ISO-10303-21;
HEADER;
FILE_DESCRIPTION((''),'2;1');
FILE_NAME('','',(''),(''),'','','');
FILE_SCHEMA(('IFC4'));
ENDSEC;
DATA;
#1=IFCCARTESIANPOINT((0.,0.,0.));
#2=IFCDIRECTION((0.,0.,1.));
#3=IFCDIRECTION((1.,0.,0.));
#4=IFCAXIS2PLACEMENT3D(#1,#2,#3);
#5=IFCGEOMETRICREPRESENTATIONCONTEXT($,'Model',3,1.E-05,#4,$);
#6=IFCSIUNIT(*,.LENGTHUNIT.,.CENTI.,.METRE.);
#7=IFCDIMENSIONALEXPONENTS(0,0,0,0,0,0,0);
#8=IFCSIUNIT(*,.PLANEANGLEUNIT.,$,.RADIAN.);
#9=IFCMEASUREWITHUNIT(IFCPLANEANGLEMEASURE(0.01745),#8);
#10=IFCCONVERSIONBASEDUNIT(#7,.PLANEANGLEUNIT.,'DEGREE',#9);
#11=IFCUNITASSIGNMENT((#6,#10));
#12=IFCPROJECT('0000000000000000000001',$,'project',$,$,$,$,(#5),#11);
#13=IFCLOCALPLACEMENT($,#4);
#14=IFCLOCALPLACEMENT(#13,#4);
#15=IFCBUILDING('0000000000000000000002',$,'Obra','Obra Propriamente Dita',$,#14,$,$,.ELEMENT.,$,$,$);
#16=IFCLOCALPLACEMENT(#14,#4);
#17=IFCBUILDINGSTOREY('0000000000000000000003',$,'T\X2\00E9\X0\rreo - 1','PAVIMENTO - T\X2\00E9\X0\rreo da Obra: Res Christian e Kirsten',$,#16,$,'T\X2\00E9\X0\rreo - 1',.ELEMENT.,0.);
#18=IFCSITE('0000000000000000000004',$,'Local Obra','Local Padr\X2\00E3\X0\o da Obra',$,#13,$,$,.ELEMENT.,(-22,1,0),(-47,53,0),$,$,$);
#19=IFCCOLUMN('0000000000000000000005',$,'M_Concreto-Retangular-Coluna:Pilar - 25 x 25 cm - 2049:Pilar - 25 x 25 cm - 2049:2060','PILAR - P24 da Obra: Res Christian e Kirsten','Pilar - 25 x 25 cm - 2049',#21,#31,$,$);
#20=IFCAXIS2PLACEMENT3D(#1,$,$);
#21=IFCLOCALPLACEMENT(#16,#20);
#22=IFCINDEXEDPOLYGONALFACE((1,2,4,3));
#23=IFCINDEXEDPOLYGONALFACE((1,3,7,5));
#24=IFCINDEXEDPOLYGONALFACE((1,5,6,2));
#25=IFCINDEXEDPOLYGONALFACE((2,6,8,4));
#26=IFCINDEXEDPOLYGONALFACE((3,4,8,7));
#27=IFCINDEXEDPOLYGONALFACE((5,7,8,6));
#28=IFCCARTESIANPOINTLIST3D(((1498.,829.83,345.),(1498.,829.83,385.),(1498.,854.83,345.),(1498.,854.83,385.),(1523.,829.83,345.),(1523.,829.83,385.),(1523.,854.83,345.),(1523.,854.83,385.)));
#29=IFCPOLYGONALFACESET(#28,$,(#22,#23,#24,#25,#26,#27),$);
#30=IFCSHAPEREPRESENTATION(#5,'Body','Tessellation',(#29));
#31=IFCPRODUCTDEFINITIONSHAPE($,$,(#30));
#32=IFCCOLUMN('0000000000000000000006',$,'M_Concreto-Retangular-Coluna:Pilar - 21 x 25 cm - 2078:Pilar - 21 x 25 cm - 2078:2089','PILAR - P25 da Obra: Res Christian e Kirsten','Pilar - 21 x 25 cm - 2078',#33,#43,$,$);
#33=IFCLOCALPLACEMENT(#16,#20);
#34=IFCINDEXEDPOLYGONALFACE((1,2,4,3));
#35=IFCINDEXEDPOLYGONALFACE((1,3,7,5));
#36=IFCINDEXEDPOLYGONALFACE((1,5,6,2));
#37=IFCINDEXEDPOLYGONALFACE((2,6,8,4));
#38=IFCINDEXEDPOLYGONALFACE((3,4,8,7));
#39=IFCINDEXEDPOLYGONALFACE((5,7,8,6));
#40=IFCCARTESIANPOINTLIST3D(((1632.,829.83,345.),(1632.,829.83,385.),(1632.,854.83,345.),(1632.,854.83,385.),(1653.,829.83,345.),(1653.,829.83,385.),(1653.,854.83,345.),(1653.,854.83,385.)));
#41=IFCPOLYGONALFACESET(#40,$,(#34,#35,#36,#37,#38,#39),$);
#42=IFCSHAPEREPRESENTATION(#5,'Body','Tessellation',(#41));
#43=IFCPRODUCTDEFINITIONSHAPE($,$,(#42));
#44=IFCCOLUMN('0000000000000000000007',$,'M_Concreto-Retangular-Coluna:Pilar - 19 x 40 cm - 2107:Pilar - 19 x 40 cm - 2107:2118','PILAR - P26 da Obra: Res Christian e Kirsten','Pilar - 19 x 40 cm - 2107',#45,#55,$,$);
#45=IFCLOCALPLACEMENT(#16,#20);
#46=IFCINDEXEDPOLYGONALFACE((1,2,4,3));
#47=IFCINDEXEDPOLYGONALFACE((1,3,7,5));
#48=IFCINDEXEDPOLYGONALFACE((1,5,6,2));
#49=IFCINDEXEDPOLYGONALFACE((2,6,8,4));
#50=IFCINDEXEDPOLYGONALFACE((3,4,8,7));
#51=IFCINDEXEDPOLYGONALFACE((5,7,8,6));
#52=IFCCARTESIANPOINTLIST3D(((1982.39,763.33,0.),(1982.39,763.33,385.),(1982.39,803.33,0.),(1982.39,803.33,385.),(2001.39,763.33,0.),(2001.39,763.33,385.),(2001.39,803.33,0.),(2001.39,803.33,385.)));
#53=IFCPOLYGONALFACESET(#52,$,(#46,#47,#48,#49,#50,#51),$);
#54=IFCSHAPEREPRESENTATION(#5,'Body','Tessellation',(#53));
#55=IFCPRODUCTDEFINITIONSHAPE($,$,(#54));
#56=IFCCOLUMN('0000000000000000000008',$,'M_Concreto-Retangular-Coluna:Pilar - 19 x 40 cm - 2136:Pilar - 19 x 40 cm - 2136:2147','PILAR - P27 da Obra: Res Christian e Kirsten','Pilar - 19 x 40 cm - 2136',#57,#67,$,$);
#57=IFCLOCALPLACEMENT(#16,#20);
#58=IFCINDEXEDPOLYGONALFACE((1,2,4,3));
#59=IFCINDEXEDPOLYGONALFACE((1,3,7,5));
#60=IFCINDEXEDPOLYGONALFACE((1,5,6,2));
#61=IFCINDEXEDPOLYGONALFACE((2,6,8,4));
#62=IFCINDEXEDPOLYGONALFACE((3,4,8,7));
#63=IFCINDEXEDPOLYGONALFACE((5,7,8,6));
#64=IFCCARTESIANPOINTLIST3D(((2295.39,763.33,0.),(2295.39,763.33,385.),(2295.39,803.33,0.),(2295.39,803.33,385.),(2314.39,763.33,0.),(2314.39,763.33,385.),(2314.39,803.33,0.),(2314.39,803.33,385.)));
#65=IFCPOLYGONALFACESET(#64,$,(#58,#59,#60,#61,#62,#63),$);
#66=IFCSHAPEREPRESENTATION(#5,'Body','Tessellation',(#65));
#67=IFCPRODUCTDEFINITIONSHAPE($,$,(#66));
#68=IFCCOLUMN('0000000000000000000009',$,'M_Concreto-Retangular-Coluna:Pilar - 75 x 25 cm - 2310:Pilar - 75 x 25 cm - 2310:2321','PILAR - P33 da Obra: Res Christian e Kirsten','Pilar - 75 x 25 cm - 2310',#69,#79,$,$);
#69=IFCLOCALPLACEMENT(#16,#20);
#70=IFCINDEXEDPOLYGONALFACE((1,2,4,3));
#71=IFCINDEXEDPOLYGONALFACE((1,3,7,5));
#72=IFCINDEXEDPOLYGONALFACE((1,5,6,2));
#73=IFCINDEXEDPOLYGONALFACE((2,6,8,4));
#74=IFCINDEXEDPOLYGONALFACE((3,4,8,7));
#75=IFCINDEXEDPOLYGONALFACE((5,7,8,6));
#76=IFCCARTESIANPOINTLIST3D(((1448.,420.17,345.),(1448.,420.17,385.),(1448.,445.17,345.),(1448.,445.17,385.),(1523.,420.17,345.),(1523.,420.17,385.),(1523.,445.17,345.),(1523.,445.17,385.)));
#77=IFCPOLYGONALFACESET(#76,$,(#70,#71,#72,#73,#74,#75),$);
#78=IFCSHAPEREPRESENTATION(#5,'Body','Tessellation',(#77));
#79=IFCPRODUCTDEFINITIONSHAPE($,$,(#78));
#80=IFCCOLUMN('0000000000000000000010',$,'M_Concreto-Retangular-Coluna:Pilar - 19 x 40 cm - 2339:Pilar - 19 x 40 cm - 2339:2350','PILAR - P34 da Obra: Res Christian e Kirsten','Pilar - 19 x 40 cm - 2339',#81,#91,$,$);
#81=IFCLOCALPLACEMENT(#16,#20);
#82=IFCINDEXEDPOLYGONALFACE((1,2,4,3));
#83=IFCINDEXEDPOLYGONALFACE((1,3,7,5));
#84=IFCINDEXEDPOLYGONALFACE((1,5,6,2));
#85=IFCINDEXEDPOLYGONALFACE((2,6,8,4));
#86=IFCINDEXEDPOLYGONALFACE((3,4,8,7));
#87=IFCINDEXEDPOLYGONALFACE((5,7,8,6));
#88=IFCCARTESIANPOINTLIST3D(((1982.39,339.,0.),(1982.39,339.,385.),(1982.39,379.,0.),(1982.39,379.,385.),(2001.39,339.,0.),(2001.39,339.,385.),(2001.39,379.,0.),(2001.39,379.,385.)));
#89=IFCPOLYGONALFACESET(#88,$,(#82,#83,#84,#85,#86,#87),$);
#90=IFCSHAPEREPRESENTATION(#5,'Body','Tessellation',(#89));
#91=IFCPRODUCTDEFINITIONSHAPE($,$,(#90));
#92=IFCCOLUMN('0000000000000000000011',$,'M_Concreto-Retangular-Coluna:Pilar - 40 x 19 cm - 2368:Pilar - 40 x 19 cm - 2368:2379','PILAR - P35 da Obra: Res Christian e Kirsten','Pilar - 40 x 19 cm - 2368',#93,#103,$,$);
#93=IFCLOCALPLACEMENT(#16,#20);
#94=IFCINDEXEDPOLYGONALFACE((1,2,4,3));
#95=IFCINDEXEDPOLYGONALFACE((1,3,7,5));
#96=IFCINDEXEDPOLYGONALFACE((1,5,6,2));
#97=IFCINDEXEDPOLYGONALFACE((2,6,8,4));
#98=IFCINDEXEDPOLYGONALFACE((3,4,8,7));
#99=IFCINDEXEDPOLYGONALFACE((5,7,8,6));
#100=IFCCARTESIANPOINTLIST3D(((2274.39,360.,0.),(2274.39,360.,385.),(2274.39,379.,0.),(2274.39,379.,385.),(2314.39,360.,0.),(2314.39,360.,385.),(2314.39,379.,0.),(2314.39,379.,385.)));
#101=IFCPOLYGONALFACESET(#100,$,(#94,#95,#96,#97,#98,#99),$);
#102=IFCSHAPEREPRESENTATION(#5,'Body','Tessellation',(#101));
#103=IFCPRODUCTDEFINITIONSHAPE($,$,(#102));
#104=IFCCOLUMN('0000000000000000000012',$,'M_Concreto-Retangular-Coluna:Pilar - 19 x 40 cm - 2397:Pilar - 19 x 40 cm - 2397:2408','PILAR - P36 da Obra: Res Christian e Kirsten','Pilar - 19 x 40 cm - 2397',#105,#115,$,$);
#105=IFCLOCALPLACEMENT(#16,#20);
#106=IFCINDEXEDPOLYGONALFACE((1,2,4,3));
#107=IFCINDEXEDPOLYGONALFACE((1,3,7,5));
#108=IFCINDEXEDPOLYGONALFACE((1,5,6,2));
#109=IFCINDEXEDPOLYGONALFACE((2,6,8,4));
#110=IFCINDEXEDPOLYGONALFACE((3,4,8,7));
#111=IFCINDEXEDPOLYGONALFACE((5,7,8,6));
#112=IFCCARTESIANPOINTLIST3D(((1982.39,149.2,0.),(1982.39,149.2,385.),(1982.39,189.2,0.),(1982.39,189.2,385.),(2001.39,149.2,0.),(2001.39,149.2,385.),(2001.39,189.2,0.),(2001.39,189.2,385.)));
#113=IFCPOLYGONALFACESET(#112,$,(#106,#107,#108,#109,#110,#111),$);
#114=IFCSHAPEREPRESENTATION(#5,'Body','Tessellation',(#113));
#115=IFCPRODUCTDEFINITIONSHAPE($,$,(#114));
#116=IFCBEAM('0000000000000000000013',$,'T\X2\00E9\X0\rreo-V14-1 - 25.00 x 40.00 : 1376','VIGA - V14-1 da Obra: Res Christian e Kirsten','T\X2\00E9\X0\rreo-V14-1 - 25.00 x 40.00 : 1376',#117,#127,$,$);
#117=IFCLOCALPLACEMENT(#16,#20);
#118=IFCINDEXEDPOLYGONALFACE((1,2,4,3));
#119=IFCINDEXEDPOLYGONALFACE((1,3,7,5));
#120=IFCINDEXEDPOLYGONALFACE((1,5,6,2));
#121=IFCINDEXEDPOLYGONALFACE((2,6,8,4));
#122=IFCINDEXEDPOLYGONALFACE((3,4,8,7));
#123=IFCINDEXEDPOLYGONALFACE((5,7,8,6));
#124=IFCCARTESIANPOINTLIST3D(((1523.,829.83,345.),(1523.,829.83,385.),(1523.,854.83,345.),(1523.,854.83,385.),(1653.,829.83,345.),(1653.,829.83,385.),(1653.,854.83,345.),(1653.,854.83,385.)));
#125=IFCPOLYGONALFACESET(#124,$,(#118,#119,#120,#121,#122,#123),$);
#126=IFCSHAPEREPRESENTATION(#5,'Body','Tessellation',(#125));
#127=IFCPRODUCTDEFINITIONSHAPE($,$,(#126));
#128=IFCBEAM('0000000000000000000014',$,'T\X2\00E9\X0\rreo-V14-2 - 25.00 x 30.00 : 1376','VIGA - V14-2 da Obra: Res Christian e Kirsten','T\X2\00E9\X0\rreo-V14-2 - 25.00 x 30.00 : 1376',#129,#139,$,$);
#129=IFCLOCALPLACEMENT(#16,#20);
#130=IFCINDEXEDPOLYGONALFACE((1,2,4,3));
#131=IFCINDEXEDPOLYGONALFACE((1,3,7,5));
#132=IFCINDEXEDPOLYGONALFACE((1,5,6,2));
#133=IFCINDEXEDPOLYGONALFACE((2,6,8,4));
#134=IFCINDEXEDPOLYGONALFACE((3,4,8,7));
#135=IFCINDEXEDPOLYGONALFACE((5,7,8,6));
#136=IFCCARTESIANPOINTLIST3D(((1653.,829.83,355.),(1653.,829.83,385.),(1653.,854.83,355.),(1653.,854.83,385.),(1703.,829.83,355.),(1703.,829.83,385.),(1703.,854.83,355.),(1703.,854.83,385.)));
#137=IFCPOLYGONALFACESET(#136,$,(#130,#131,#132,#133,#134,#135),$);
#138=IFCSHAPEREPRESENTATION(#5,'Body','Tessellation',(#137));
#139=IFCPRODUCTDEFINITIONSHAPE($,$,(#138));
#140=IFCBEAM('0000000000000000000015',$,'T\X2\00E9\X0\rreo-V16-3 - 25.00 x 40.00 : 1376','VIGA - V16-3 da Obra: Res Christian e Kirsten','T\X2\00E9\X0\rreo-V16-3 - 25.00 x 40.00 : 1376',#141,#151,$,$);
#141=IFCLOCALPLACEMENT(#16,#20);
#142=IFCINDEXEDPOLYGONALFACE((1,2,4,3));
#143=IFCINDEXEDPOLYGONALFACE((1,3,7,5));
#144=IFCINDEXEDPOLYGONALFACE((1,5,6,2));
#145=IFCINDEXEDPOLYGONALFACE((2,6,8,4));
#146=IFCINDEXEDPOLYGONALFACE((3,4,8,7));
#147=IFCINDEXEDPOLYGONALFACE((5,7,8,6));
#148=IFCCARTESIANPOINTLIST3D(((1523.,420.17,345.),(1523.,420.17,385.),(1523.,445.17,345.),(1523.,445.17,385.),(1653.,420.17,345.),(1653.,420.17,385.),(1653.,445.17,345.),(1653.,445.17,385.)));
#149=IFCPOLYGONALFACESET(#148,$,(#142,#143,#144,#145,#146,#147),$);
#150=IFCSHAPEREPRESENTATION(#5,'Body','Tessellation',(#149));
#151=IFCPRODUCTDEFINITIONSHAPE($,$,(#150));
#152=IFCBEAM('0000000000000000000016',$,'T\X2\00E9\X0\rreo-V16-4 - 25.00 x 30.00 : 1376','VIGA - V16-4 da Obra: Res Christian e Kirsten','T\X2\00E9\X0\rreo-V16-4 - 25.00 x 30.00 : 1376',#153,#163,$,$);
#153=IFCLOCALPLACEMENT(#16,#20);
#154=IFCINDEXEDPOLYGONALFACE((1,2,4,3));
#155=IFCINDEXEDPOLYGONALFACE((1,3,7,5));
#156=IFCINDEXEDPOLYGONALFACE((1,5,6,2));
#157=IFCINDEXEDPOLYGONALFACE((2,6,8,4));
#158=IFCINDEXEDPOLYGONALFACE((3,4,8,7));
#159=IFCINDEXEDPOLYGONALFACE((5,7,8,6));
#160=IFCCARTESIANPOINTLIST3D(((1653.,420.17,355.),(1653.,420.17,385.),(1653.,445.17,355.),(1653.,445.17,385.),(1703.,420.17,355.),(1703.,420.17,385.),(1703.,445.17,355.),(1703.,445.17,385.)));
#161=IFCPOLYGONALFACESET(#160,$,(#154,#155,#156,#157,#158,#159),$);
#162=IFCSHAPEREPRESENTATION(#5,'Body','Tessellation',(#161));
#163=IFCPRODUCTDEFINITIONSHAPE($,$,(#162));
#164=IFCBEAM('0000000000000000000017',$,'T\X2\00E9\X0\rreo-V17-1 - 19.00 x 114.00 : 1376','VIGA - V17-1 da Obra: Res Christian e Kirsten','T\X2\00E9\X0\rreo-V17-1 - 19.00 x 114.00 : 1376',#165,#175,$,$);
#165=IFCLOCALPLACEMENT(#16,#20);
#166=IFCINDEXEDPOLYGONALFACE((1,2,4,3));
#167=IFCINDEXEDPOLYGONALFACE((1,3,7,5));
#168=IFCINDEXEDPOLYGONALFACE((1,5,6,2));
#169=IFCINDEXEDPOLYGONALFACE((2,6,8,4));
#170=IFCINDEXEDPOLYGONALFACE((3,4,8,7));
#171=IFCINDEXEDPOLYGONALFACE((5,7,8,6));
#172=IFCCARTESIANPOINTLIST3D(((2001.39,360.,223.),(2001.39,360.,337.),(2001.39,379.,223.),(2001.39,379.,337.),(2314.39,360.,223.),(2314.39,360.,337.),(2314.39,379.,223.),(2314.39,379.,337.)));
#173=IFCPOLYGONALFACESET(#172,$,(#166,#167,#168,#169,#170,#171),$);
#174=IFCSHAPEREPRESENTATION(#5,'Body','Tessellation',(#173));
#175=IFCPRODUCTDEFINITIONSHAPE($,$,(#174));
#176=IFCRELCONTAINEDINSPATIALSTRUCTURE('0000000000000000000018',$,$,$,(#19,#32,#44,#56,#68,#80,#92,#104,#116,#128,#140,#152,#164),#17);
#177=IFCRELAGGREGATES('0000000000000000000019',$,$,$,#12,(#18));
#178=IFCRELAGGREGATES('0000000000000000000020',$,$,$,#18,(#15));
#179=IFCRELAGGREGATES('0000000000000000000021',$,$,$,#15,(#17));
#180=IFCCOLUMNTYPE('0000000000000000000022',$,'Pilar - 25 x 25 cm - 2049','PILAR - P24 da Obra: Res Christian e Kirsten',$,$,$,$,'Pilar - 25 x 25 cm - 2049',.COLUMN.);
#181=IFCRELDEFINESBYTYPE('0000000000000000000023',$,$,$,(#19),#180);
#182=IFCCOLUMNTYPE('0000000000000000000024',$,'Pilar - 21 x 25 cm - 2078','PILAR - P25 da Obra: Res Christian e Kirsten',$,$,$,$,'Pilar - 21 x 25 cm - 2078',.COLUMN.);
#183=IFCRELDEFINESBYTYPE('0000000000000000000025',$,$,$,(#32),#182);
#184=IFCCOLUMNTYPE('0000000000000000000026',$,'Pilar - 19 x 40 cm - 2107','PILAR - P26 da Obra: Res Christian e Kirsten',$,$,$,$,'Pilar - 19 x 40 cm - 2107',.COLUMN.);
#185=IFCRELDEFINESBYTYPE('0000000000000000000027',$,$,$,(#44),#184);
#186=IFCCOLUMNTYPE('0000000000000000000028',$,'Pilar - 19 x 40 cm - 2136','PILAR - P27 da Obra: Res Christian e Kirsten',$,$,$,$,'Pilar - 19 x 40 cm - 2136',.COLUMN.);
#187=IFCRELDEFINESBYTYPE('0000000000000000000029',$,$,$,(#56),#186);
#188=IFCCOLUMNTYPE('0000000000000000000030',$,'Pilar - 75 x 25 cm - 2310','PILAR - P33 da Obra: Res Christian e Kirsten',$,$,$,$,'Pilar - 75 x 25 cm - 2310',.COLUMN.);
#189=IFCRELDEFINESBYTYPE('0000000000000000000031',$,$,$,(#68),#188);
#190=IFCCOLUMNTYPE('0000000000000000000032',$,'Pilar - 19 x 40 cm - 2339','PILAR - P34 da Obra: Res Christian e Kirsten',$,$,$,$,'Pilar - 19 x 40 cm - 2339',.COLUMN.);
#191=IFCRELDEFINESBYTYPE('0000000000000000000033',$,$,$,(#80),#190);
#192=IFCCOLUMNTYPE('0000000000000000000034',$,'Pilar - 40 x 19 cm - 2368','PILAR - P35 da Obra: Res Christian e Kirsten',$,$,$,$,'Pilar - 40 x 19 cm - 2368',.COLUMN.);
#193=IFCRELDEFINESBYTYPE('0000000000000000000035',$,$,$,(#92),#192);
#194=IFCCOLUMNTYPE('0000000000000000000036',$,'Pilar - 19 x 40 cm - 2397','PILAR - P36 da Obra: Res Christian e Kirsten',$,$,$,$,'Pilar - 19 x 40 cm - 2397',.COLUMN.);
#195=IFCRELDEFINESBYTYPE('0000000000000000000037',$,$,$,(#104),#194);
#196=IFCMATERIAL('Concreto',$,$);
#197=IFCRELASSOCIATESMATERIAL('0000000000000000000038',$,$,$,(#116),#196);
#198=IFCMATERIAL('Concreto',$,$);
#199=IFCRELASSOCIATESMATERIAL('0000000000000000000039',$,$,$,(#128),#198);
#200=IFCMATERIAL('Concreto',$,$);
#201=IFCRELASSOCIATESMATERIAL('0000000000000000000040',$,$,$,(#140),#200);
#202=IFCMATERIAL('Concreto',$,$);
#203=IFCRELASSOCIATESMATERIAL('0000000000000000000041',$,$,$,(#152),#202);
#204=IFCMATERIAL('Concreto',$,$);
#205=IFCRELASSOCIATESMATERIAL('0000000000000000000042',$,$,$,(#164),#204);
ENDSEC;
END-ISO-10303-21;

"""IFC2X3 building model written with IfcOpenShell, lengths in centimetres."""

from ifc_helpers import new_model, entity, si_unit, converted_unit, frame, origin, origin_with_axes, origin_2d_with_axis, place, context, project, spatial, polyline, rectangle, outline, extrude, source, transform, mapped, material, type_object, type_shapes, element, save


model = new_model("IFC2X3")

# Units and contexts
model_context = context("Model", 3, precision=1e-05, world=origin_with_axes())
ifc_project = project(units=[si_unit("LENGTHUNIT", "METRE", prefix="CENTI"), converted_unit("PLANEANGLEUNIT", "DEGREE", entity("IfcPlaneAngleMeasure", 0.01745), si_unit("PLANEANGLEUNIT", "RADIAN"), dimensions=[0, 0, 0, 0, 0, 0, 0])], contexts=[model_context])

# Site, building, storey
site_placement = place(None, origin_with_axes())
site = spatial("IfcSite", under=ifc_project, at=site_placement, Name="Local Obra", Description="Local Padrão da Obra", CompositionType="ELEMENT", RefLatitude=(-22, 1, 0), RefLongitude=(-47, 53, 0))
building_placement = place(site_placement, origin_with_axes())
building = spatial("IfcBuilding", under=site, at=building_placement, Name="Obra", Description="Obra Propriamente Dita", CompositionType="ELEMENT")
storey_placement = place(building_placement, origin_with_axes())
storey = spatial("IfcBuildingStorey", under=building, at=storey_placement, Name="Térreo - 1", Description="PAVIMENTO - Térreo da Obra: Res Christian e Kirsten", LongName="Térreo - 1", CompositionType="ELEMENT", Elevation=0.0)

# Columns
column_type_1 = type_object("IfcColumnType", Name="Pilar - 25 x 25 cm - 2049", Description="PILAR - P24 da Obra: Res Christian e Kirsten", ElementType="Pilar - 25 x 25 cm - 2049", PredefinedType="COLUMN")
shared_shape_1 = source(origin(), model_context, "Body", "SweptSolid", [
    extrude(rectangle(XDim=25.0, YDim=25.0, at=origin_2d_with_axis()), origin(), (0.0, 0.0, 1.0), 40.0),
])
type_shapes(column_type_1, [shared_shape_1])
column_1_placement = place(storey_placement, frame((1510.5, 842.33, 345.0), z_axis=(0.0, 0.0, 1.0), x_axis=(1.0, 0.0, 0.0)))
element("IfcColumn", 1, at=column_1_placement, inside=storey, type_object=column_type_1, Name="M_Concreto-Retangular-Coluna:Pilar - 25 x 25 cm - 2049:Pilar - 25 x 25 cm - 2049:2060", Description="PILAR - P24 da Obra: Res Christian e Kirsten", ObjectType="Pilar - 25 x 25 cm - 2049", context=model_context, shape_type="MappedRepresentation", body=[
    mapped(shared_shape_1, transform((0.0, 0.0, 0.0), scale=1.0)),
])
column_type_2 = type_object("IfcColumnType", Name="Pilar - 21 x 25 cm - 2078", Description="PILAR - P25 da Obra: Res Christian e Kirsten", ElementType="Pilar - 21 x 25 cm - 2078", PredefinedType="COLUMN")
shared_shape_2 = source(origin(), model_context, "Body", "SweptSolid", [
    extrude(rectangle(XDim=21.0, YDim=25.0, at=origin_2d_with_axis()), origin(), (0.0, 0.0, 1.0), 40.0),
])
type_shapes(column_type_2, [shared_shape_2])
column_2_placement = place(storey_placement, frame((1642.5, 842.33, 345.0), z_axis=(0.0, 0.0, 1.0), x_axis=(1.0, 0.0, 0.0)))
element("IfcColumn", 2, at=column_2_placement, inside=storey, type_object=column_type_2, Name="M_Concreto-Retangular-Coluna:Pilar - 21 x 25 cm - 2078:Pilar - 21 x 25 cm - 2078:2089", Description="PILAR - P25 da Obra: Res Christian e Kirsten", ObjectType="Pilar - 21 x 25 cm - 2078", context=model_context, shape_type="MappedRepresentation", body=[
    mapped(shared_shape_2, transform((0.0, 0.0, 0.0), scale=1.0)),
])
column_type_3 = type_object("IfcColumnType", Name="Pilar - 19 x 40 cm - 2107", Description="PILAR - P26 da Obra: Res Christian e Kirsten", ElementType="Pilar - 19 x 40 cm - 2107", PredefinedType="COLUMN")
shared_shape_3 = source(origin(), model_context, "Body", "SweptSolid", [
    extrude(rectangle(XDim=19.0, YDim=40.0, at=origin_2d_with_axis()), origin(), (0.0, 0.0, 1.0), 385.0),
])
type_shapes(column_type_3, [shared_shape_3])
column_3_placement = place(storey_placement, frame((1991.89, 783.33, 0.0), z_axis=(0.0, 0.0, 1.0), x_axis=(1.0, 0.0, 0.0)))
element("IfcColumn", 3, at=column_3_placement, inside=storey, type_object=column_type_3, Name="M_Concreto-Retangular-Coluna:Pilar - 19 x 40 cm - 2107:Pilar - 19 x 40 cm - 2107:2118", Description="PILAR - P26 da Obra: Res Christian e Kirsten", ObjectType="Pilar - 19 x 40 cm - 2107", context=model_context, shape_type="MappedRepresentation", body=[
    mapped(shared_shape_3, transform((0.0, 0.0, 0.0), scale=1.0)),
])
column_type_4 = type_object("IfcColumnType", Name="Pilar - 19 x 40 cm - 2136", Description="PILAR - P27 da Obra: Res Christian e Kirsten", ElementType="Pilar - 19 x 40 cm - 2136", PredefinedType="COLUMN")
shared_shape_4 = source(origin(), model_context, "Body", "SweptSolid", [
    extrude(rectangle(XDim=19.0, YDim=40.0, at=origin_2d_with_axis()), origin(), (0.0, 0.0, 1.0), 385.0),
])
type_shapes(column_type_4, [shared_shape_4])
column_4_placement = place(storey_placement, frame((2304.89, 783.33, 0.0), z_axis=(0.0, 0.0, 1.0), x_axis=(1.0, 0.0, 0.0)))
element("IfcColumn", 4, at=column_4_placement, inside=storey, type_object=column_type_4, Name="M_Concreto-Retangular-Coluna:Pilar - 19 x 40 cm - 2136:Pilar - 19 x 40 cm - 2136:2147", Description="PILAR - P27 da Obra: Res Christian e Kirsten", ObjectType="Pilar - 19 x 40 cm - 2136", context=model_context, shape_type="MappedRepresentation", body=[
    mapped(shared_shape_4, transform((0.0, 0.0, 0.0), scale=1.0)),
])
column_type_5 = type_object("IfcColumnType", Name="Pilar - 75 x 25 cm - 2310", Description="PILAR - P33 da Obra: Res Christian e Kirsten", ElementType="Pilar - 75 x 25 cm - 2310", PredefinedType="COLUMN")
shared_shape_5 = source(origin(), model_context, "Body", "SweptSolid", [
    extrude(rectangle(XDim=75.0, YDim=25.0, at=origin_2d_with_axis()), origin(), (0.0, 0.0, 1.0), 40.0),
])
type_shapes(column_type_5, [shared_shape_5])
column_5_placement = place(storey_placement, frame((1485.5, 432.67, 345.0), z_axis=(0.0, 0.0, 1.0), x_axis=(1.0, 0.0, 0.0)))
element("IfcColumn", 5, at=column_5_placement, inside=storey, type_object=column_type_5, Name="M_Concreto-Retangular-Coluna:Pilar - 75 x 25 cm - 2310:Pilar - 75 x 25 cm - 2310:2321", Description="PILAR - P33 da Obra: Res Christian e Kirsten", ObjectType="Pilar - 75 x 25 cm - 2310", context=model_context, shape_type="MappedRepresentation", body=[
    mapped(shared_shape_5, transform((0.0, 0.0, 0.0), scale=1.0)),
])
column_type_6 = type_object("IfcColumnType", Name="Pilar - 19 x 40 cm - 2339", Description="PILAR - P34 da Obra: Res Christian e Kirsten", ElementType="Pilar - 19 x 40 cm - 2339", PredefinedType="COLUMN")
shared_shape_6 = source(origin(), model_context, "Body", "SweptSolid", [
    extrude(rectangle(XDim=19.0, YDim=40.0, at=origin_2d_with_axis()), origin(), (0.0, 0.0, 1.0), 385.0),
])
type_shapes(column_type_6, [shared_shape_6])
column_6_placement = place(storey_placement, frame((1991.89, 359.0, 0.0), z_axis=(0.0, 0.0, 1.0), x_axis=(1.0, 0.0, 0.0)))
element("IfcColumn", 6, at=column_6_placement, inside=storey, type_object=column_type_6, Name="M_Concreto-Retangular-Coluna:Pilar - 19 x 40 cm - 2339:Pilar - 19 x 40 cm - 2339:2350", Description="PILAR - P34 da Obra: Res Christian e Kirsten", ObjectType="Pilar - 19 x 40 cm - 2339", context=model_context, shape_type="MappedRepresentation", body=[
    mapped(shared_shape_6, transform((0.0, 0.0, 0.0), scale=1.0)),
])
column_type_7 = type_object("IfcColumnType", Name="Pilar - 40 x 19 cm - 2368", Description="PILAR - P35 da Obra: Res Christian e Kirsten", ElementType="Pilar - 40 x 19 cm - 2368", PredefinedType="COLUMN")
shared_shape_7 = source(origin(), model_context, "Body", "SweptSolid", [
    extrude(rectangle(XDim=40.0, YDim=19.0, at=origin_2d_with_axis()), origin(), (0.0, 0.0, 1.0), 385.0),
])
type_shapes(column_type_7, [shared_shape_7])
column_7_placement = place(storey_placement, frame((2294.39, 369.5, 0.0), z_axis=(0.0, 0.0, 1.0), x_axis=(1.0, 0.0, 0.0)))
element("IfcColumn", 7, at=column_7_placement, inside=storey, type_object=column_type_7, Name="M_Concreto-Retangular-Coluna:Pilar - 40 x 19 cm - 2368:Pilar - 40 x 19 cm - 2368:2379", Description="PILAR - P35 da Obra: Res Christian e Kirsten", ObjectType="Pilar - 40 x 19 cm - 2368", context=model_context, shape_type="MappedRepresentation", body=[
    mapped(shared_shape_7, transform((0.0, 0.0, 0.0), scale=1.0)),
])
column_type_8 = type_object("IfcColumnType", Name="Pilar - 19 x 40 cm - 2397", Description="PILAR - P36 da Obra: Res Christian e Kirsten", ElementType="Pilar - 19 x 40 cm - 2397", PredefinedType="COLUMN")
shared_shape_8 = source(origin(), model_context, "Body", "SweptSolid", [
    extrude(rectangle(XDim=19.0, YDim=40.0, at=origin_2d_with_axis()), origin(), (0.0, 0.0, 1.0), 385.0),
])
type_shapes(column_type_8, [shared_shape_8])
column_8_placement = place(storey_placement, frame((1991.89, 169.2, 0.0), z_axis=(0.0, 0.0, 1.0), x_axis=(1.0, 0.0, 0.0)))
element("IfcColumn", 8, at=column_8_placement, inside=storey, type_object=column_type_8, Name="M_Concreto-Retangular-Coluna:Pilar - 19 x 40 cm - 2397:Pilar - 19 x 40 cm - 2397:2408", Description="PILAR - P36 da Obra: Res Christian e Kirsten", ObjectType="Pilar - 19 x 40 cm - 2397", context=model_context, shape_type="MappedRepresentation", body=[
    mapped(shared_shape_8, transform((0.0, 0.0, 0.0), scale=1.0)),
])

# Beams
ifc_material_1 = material(Name="Concreto")
beam_1_placement = place(storey_placement, frame((1523.0, 842.33, 385.0), z_axis=(1.0, 0.0, 0.0), x_axis=(0.0, -1.0, 0.0)))
element("IfcBeam", 9, at=beam_1_placement, inside=storey, material=ifc_material_1, Name="Térreo-V14-1 - 25.00 x 40.00 : 1376", Description="VIGA - V14-1 da Obra: Res Christian e Kirsten", ObjectType="Térreo-V14-1 - 25.00 x 40.00 : 1376", context=model_context, shape_type="SweptSolid", body=[
    extrude(outline(polyline([(-12.5, 0.0), (12.5, 0.0), (12.5, 40.0), (-12.5, 40.0), (-12.5, 0.0)])), origin_with_axes(), (0.0, 0.0, 1.0), 130.0),
])
ifc_material_2 = material(Name="Concreto")
beam_2_placement = place(storey_placement, frame((1653.0, 842.33, 385.0), z_axis=(1.0, -0.000066, 0.0), x_axis=(-0.000066, -1.0, 0.0)))
element("IfcBeam", 10, at=beam_2_placement, inside=storey, material=ifc_material_2, Name="Térreo-V14-2 - 25.00 x 30.00 : 1376", Description="VIGA - V14-2 da Obra: Res Christian e Kirsten", ObjectType="Térreo-V14-2 - 25.00 x 30.00 : 1376", context=model_context, shape_type="SweptSolid", body=[
    extrude(outline(polyline([(-12.5, 0.0), (12.5, 0.0), (12.5, 30.0), (-12.5, 30.0), (-12.5, 0.0)])), origin_with_axes(), (0.0, 0.0, 1.0), 50.0),
])
ifc_material_3 = material(Name="Concreto")
beam_3_placement = place(storey_placement, frame((1523.0, 432.67, 385.0), z_axis=(1.0, 0.0, 0.0), x_axis=(0.0, -1.0, 0.0)))
element("IfcBeam", 11, at=beam_3_placement, inside=storey, material=ifc_material_3, Name="Térreo-V16-3 - 25.00 x 40.00 : 1376", Description="VIGA - V16-3 da Obra: Res Christian e Kirsten", ObjectType="Térreo-V16-3 - 25.00 x 40.00 : 1376", context=model_context, shape_type="SweptSolid", body=[
    extrude(outline(polyline([(-12.5, 0.0), (12.5, 0.0), (12.5, 40.0), (-12.5, 40.0), (-12.5, 0.0)])), origin_with_axes(), (0.0, 0.0, 1.0), 130.0),
])
ifc_material_4 = material(Name="Concreto")
beam_4_placement = place(storey_placement, frame((1653.0, 432.67, 385.0), z_axis=(1.0, 0.000068, 0.0), x_axis=(0.000068, -1.0, 0.0)))
element("IfcBeam", 12, at=beam_4_placement, inside=storey, material=ifc_material_4, Name="Térreo-V16-4 - 25.00 x 30.00 : 1376", Description="VIGA - V16-4 da Obra: Res Christian e Kirsten", ObjectType="Térreo-V16-4 - 25.00 x 30.00 : 1376", context=model_context, shape_type="SweptSolid", body=[
    extrude(outline(polyline([(-12.5, 0.0), (12.5, 0.0), (12.5, 30.0), (-12.5, 30.0), (-12.5, 0.0)])), origin_with_axes(), (0.0, 0.0, 1.0), 50.0),
])
ifc_material_5 = material(Name="Concreto")
beam_5_placement = place(storey_placement, frame((2001.39, 379.0, 337.0), z_axis=(1.0, 0.0, 0.0), x_axis=(0.0, -1.0, 0.0)))
element("IfcBeam", 13, at=beam_5_placement, inside=storey, material=ifc_material_5, Name="Térreo-V17-1 - 19.00 x 114.00 : 1376", Description="VIGA - V17-1 da Obra: Res Christian e Kirsten", ObjectType="Térreo-V17-1 - 19.00 x 114.00 : 1376", context=model_context, shape_type="SweptSolid", body=[
    extrude(outline(polyline([(0.0, 0.0), (19.0, 0.0), (19.0, 114.0), (0.0, 114.0), (0.0, 0.0)])), origin_with_axes(), (0.0, 0.0, 1.0), 313.0),
])

save(model, "model.ifc")
